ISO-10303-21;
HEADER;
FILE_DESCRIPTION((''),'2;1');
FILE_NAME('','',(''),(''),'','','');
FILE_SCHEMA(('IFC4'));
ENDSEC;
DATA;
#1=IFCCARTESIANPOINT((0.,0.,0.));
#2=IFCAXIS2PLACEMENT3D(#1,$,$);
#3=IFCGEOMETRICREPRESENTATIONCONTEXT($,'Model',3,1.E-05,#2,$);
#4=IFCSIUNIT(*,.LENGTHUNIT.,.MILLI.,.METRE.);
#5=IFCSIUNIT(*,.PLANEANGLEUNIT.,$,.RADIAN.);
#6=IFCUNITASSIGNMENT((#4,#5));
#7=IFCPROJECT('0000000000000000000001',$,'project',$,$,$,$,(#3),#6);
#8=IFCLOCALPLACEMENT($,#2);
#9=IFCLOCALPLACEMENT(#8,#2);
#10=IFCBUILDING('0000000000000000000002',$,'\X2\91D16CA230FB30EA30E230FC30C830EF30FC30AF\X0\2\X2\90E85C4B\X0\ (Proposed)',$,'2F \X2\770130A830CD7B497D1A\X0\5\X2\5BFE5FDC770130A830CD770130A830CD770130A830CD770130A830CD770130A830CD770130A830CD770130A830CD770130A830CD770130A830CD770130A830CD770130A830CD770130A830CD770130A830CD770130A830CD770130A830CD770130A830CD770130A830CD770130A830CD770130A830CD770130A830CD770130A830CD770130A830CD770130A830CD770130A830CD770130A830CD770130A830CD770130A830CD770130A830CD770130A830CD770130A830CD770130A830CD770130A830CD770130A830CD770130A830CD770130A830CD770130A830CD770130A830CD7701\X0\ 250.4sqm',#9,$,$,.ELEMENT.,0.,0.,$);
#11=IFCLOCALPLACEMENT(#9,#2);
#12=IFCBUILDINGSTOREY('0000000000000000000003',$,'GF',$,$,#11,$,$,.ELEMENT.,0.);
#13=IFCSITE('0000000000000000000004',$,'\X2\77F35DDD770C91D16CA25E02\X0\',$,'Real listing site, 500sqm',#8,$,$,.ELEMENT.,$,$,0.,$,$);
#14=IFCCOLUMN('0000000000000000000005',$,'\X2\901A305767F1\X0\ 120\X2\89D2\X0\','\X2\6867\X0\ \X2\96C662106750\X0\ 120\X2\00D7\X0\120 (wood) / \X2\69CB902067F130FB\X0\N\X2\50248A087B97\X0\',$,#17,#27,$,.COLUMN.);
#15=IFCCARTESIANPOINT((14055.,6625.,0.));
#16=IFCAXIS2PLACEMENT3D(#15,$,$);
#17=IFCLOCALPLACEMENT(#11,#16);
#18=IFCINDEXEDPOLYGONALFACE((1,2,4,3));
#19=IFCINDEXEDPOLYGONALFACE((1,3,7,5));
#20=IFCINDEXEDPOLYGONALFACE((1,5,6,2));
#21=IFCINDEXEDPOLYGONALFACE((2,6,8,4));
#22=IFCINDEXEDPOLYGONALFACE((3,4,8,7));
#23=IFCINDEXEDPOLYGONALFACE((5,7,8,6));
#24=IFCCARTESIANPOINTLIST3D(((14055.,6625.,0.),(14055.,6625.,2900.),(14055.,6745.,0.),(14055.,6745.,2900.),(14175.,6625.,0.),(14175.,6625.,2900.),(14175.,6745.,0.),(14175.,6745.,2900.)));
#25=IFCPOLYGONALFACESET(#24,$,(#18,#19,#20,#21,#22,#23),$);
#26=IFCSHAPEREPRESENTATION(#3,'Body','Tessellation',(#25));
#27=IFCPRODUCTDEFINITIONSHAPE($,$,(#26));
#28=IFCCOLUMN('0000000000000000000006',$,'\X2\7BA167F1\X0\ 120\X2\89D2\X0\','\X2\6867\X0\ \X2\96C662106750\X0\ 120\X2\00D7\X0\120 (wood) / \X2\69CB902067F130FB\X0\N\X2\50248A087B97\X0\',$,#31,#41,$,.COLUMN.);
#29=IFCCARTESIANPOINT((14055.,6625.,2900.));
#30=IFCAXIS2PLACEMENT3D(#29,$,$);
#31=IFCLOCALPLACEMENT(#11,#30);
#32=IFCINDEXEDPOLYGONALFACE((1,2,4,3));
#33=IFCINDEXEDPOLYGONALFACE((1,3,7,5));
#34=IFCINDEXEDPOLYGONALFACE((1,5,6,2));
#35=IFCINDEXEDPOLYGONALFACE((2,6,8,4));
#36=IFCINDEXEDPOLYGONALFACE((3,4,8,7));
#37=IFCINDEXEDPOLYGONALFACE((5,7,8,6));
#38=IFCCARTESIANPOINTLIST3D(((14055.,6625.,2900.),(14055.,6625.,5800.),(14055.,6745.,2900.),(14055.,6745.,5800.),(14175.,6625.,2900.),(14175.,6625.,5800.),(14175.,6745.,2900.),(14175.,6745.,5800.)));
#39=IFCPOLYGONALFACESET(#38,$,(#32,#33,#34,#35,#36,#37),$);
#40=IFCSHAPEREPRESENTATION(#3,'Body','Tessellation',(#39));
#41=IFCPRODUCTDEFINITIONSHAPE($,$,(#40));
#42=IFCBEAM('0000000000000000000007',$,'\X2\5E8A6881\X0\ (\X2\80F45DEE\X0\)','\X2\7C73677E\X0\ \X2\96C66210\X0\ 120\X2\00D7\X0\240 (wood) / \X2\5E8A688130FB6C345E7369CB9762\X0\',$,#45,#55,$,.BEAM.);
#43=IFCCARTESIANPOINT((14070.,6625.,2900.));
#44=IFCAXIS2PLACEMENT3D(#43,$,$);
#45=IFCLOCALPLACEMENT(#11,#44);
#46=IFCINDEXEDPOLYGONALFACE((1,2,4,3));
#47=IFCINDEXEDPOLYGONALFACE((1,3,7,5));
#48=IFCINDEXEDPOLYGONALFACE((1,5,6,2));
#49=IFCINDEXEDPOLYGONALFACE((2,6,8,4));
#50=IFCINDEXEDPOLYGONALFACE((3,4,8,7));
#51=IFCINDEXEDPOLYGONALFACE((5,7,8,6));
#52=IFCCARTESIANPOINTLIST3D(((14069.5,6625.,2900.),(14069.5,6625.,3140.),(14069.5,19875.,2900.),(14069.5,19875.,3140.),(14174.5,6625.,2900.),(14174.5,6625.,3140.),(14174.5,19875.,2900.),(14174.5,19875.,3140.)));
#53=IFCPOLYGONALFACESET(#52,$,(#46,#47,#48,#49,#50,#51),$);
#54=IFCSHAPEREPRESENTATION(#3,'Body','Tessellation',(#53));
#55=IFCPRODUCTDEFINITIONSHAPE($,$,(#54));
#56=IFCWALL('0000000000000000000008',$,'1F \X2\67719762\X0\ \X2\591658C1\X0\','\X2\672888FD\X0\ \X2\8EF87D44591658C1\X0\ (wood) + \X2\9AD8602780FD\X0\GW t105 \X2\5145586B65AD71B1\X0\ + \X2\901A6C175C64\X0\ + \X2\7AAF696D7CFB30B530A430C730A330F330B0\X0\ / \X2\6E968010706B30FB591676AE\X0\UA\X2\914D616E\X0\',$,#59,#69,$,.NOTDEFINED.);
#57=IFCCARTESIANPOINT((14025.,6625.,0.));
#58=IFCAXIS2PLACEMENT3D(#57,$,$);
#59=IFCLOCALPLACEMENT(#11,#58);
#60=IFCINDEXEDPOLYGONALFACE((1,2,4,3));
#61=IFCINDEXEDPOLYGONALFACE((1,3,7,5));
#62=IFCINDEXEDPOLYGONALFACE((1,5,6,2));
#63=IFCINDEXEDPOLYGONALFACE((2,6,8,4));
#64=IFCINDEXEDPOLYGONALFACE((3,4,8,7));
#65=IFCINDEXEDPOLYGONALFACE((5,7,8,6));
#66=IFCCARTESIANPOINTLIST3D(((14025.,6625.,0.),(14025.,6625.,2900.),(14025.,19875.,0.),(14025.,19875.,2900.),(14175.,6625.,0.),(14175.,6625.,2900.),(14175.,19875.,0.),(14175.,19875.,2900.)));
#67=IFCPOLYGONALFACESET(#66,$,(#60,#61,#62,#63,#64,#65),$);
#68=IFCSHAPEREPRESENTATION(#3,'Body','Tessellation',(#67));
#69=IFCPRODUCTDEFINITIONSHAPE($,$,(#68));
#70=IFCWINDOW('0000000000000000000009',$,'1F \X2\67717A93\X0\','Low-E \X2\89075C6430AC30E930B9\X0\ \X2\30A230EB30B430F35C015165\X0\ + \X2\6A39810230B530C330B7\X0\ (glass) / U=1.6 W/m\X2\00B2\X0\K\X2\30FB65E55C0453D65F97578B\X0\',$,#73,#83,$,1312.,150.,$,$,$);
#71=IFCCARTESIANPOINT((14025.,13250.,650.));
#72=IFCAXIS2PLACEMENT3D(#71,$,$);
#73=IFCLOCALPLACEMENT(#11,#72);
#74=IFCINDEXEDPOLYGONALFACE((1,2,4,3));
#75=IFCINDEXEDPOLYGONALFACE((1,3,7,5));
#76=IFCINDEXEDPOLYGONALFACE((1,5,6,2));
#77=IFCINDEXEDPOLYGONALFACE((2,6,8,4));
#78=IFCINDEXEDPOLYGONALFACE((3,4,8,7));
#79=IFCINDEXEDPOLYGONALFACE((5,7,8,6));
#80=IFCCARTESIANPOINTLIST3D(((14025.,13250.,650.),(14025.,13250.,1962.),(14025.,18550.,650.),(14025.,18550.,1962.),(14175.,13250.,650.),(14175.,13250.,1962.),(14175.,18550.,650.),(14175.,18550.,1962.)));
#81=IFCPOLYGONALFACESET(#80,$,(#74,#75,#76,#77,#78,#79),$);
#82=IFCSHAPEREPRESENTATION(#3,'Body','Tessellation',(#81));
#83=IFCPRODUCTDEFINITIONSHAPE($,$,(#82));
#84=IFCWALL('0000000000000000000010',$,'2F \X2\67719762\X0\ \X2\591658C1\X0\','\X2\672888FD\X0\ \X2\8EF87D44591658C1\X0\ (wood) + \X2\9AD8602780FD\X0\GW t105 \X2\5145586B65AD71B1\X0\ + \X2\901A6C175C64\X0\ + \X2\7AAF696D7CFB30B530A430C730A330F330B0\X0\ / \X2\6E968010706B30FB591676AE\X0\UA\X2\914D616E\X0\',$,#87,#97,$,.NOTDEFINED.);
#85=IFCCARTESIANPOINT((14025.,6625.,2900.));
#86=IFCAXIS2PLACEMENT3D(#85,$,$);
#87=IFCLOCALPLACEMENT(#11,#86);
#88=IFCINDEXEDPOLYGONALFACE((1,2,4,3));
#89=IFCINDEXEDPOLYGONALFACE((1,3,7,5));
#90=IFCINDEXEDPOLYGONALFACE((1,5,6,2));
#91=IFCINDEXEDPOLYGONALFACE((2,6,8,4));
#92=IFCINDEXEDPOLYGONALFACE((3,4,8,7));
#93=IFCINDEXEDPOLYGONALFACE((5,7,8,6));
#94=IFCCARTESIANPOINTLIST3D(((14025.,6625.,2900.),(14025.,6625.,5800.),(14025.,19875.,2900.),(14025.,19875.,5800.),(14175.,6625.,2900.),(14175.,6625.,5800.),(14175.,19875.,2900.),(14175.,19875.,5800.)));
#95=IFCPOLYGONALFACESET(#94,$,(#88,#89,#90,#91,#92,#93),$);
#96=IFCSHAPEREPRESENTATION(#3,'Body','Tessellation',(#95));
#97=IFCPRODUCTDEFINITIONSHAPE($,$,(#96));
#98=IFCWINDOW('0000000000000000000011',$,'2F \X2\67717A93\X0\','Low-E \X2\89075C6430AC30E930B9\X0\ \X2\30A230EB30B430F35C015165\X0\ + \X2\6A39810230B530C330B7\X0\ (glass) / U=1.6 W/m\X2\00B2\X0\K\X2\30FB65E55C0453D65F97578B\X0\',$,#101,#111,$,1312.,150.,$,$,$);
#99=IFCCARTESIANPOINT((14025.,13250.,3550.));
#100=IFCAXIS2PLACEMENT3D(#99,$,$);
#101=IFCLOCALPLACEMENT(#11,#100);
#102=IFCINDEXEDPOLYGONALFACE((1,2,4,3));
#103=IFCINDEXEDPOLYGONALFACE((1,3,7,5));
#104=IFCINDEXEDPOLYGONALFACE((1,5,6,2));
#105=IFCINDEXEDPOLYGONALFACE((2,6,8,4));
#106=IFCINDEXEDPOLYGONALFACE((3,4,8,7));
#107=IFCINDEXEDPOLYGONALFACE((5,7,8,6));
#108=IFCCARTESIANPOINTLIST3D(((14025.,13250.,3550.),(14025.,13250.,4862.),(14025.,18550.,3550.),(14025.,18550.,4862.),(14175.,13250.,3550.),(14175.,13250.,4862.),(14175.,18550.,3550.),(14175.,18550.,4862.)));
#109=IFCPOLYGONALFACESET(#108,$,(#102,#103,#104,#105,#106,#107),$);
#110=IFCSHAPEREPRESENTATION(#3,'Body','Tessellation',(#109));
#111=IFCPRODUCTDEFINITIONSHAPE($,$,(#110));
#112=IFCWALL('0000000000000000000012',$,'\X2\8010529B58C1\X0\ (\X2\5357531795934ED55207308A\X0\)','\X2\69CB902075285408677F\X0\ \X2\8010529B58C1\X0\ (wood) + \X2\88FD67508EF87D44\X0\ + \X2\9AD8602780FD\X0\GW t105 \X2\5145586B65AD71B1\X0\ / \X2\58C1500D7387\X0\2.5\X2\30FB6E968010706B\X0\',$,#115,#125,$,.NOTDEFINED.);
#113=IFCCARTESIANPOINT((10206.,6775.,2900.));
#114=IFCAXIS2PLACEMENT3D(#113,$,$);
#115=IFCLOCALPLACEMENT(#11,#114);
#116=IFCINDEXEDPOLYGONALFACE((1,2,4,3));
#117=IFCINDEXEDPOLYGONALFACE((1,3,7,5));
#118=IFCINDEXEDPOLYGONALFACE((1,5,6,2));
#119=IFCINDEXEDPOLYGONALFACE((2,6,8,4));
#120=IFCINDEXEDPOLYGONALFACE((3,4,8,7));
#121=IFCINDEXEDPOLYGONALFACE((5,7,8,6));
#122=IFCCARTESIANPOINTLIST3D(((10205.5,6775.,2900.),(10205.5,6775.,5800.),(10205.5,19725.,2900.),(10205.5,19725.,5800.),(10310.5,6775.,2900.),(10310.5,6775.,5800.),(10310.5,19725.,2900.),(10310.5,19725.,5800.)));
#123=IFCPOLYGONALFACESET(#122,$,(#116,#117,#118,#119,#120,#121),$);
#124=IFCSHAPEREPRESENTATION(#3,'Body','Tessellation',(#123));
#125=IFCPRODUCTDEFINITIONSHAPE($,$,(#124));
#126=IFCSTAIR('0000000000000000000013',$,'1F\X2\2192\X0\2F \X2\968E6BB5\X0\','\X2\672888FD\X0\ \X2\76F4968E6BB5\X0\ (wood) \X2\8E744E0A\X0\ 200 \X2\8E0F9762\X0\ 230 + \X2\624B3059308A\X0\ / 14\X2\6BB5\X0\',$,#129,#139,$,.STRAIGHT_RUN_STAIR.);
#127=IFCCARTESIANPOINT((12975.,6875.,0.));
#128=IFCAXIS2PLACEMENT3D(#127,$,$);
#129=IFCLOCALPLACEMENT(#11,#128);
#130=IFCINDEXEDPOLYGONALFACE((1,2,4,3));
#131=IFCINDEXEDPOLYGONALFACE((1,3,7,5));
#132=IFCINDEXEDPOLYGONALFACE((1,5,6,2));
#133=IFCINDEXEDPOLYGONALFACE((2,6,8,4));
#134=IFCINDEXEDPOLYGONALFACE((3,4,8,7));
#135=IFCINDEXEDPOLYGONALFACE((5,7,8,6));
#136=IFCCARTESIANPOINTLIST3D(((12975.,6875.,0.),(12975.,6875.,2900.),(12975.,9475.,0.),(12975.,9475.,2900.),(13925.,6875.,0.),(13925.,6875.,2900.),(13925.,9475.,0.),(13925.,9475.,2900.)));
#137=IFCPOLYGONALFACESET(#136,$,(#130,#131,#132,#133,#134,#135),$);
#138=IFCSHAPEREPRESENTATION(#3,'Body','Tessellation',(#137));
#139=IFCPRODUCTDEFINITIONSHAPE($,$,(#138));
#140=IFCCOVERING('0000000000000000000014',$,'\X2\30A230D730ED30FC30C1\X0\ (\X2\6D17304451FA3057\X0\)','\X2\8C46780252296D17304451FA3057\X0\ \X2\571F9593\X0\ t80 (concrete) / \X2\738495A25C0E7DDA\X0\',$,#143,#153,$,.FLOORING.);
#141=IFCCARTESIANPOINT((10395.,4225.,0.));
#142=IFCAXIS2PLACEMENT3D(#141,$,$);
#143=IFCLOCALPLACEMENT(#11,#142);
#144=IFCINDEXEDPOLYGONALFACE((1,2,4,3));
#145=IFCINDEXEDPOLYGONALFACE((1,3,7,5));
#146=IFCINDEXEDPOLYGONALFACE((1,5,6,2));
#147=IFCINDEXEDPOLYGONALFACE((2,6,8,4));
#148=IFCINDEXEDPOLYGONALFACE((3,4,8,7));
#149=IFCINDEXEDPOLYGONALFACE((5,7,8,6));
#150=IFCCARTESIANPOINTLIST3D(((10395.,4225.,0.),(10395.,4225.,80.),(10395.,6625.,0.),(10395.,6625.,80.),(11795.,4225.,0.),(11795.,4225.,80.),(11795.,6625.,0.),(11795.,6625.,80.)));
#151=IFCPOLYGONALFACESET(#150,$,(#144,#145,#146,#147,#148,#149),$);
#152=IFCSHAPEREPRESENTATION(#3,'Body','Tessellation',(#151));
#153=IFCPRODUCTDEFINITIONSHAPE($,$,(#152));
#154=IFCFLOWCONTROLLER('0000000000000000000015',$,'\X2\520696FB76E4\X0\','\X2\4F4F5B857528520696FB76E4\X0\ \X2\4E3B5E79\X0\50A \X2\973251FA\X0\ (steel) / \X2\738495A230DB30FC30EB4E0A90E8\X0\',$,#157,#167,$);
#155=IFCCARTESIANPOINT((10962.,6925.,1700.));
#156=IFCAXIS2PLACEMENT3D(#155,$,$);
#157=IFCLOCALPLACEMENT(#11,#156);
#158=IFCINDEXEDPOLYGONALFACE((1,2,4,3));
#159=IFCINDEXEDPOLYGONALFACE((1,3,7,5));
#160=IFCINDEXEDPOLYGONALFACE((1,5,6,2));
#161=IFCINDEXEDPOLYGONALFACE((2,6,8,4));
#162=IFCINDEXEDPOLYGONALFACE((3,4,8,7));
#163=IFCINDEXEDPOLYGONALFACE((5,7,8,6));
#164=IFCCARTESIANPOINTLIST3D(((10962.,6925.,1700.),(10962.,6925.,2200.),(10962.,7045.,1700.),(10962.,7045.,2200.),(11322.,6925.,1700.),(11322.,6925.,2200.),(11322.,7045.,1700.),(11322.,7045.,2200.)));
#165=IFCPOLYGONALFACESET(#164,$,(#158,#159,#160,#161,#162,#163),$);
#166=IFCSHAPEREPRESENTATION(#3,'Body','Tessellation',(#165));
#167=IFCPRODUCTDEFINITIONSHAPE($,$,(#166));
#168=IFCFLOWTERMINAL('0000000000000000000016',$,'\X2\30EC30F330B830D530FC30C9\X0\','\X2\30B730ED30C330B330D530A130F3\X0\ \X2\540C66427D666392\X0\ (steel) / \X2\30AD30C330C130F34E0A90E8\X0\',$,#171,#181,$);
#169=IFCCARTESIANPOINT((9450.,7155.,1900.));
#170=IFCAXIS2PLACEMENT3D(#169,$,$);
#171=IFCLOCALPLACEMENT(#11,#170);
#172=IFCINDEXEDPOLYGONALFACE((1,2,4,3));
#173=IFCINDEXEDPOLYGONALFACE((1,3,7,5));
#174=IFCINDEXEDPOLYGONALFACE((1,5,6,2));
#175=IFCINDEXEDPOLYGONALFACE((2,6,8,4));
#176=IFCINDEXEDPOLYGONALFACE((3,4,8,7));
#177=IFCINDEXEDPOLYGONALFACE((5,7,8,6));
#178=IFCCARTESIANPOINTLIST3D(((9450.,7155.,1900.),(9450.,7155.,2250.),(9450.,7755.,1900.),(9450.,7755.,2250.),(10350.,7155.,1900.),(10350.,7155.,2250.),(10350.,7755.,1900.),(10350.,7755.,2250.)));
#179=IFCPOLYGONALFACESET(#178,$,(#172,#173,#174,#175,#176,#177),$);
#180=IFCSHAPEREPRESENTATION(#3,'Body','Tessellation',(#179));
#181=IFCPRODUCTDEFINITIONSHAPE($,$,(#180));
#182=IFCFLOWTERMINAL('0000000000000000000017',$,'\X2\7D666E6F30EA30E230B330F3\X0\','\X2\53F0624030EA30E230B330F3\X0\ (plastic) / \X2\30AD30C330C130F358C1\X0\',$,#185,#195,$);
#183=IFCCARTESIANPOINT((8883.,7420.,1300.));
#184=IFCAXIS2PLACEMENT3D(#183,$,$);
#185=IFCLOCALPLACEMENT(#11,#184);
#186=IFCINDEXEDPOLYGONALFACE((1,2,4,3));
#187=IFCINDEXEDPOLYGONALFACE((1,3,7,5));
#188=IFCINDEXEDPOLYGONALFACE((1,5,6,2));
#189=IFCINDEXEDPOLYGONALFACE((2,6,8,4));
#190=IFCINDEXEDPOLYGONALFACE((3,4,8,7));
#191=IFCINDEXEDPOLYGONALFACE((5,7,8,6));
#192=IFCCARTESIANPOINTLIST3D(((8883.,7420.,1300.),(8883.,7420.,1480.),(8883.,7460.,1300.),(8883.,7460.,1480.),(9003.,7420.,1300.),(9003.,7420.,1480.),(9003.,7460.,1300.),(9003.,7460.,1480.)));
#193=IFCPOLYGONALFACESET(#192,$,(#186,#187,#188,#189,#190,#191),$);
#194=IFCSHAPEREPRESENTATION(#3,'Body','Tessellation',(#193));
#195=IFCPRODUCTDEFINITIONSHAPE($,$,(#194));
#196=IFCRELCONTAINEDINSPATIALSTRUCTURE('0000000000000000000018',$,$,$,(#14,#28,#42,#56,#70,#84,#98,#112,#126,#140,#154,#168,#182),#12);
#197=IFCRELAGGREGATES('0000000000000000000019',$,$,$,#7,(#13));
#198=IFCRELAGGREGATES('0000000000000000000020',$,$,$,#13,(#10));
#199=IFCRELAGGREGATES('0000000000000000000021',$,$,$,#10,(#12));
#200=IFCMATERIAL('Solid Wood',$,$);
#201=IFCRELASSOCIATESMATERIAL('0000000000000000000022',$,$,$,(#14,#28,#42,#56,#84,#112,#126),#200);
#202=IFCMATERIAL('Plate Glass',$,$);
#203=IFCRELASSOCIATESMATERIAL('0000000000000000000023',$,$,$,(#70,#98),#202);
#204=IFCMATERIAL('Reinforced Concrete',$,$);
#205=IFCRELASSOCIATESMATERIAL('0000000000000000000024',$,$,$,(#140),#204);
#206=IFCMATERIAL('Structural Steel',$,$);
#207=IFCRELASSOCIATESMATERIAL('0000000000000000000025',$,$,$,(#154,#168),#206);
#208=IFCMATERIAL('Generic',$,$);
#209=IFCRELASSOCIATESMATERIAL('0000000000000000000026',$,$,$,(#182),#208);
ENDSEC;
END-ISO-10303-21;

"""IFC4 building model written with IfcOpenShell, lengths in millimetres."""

from ifc_helpers import new_model, si_unit, frame, frame_2d, origin, place, context, project, spatial, rectangle, extrude, material, element, fill, save


model = new_model("IFC4")

# Units and contexts
model_context = context("Model", 3, precision=1e-05, world=origin())
ifc_project = project(units=[si_unit("LENGTHUNIT", "METRE", prefix="MILLI"), si_unit("PLANEANGLEUNIT", "RADIAN")], contexts=[model_context])

# Site, building, storey
site_placement = place(None, origin())
site = spatial("IfcSite", under=ifc_project, at=site_placement, Name="石川県金沢市", ObjectType="Real listing site, 500sqm", CompositionType="ELEMENT", RefElevation=0.0)
building_placement = place(site_placement, origin())
building = spatial("IfcBuilding", under=site, at=building_placement, Name="金沢・リモートワーク2部屋 (Proposed)", ObjectType="2F 省エネ等級5対応省エネ省エネ省エネ省エネ省エネ省エネ省エネ省エネ省エネ省エネ省エネ省エネ省エネ省エネ省エネ省エネ省エネ省エネ省エネ省エネ省エネ省エネ省エネ省エネ省エネ省エネ省エネ省エネ省エネ省エネ省エネ省エネ省エネ省エネ省エネ省エネ省エネ省 250.4sqm", CompositionType="ELEMENT", ElevationOfRefHeight=0.0, ElevationOfTerrain=0.0)
storey_placement = place(building_placement, origin())
storey = spatial("IfcBuildingStorey", under=building, at=storey_placement, Name="GF", CompositionType="ELEMENT", Elevation=0.0)

# Columns
ifc_material_1 = material(Name="Solid Wood")
column_1_placement = place(storey_placement, frame((14055.0, 6625.0, 0.0)))
element("IfcColumn", 1, at=column_1_placement, inside=storey, material=ifc_material_1, Name="通し柱 120角", Description="桧 集成材 120×120 (wood) / 構造柱・N値計算", PredefinedType="COLUMN", context=model_context, shape_type="SweptSolid", body=[
    extrude(rectangle(XDim=120.0, YDim=120.0, at=frame_2d((60.0, 60.0))), frame((14055.0, 6625.0, 0.0)), (0.0, 0.0, 1.0), 2900.0),
])
column_2_placement = place(storey_placement, frame((14055.0, 6625.0, 2900.0)))
element("IfcColumn", 2, at=column_2_placement, inside=storey, material=ifc_material_1, Name="管柱 120角", Description="桧 集成材 120×120 (wood) / 構造柱・N値計算", PredefinedType="COLUMN", context=model_context, shape_type="SweptSolid", body=[
    extrude(rectangle(XDim=120.0, YDim=120.0, at=frame_2d((60.0, 60.0))), frame((14055.0, 6625.0, 2900.0)), (0.0, 0.0, 1.0), 2900.0),
])

# Beam
beam_1_placement = place(storey_placement, frame((14070.0, 6625.0, 2900.0)))
element("IfcBeam", 3, at=beam_1_placement, inside=storey, material=ifc_material_1, Name="床梁 (胴差)", Description="米松 集成 120×240 (wood) / 床梁・水平構面", PredefinedType="BEAM", context=model_context, shape_type="SweptSolid", body=[
    extrude(rectangle(XDim=105.0, YDim=13250.0, at=frame_2d((52.0, 6625.0))), frame((14070.0, 6625.0, 2900.0)), (0.0, 0.0, 1.0), 240.0),
])

# Wall, opening, window
wall_1_placement = place(storey_placement, frame((14025.0, 6625.0, 0.0)))
wall_1 = element("IfcWall", 4, at=wall_1_placement, inside=storey, material=ifc_material_1, Name="1F 東面 外壁", Description="木製 軸組外壁 (wood) + 高性能GW t105 充填断熱 + 通気層 + 窯業系サイディング / 準耐火・外皮UA配慮", PredefinedType="NOTDEFINED", context=model_context, shape_type="SweptSolid", body=[
    extrude(rectangle(XDim=150.0, YDim=13250.0, at=frame_2d((75.0, 6625.0))), frame((14025.0, 6625.0, 0.0)), (0.0, 0.0, 1.0), 2900.0),
])
opening_1_placement = place(storey_placement, frame((14025.0, 13250.0, 650.0)))
opening_1 = element("IfcOpeningElement", 5, at=opening_1_placement, cuts=wall_1, PredefinedType="NOTDEFINED", context=model_context, shape_type="SweptSolid", body=[
    extrude(rectangle(XDim=150.0, YDim=5300.0, at=frame_2d((75.0, 2650.0))), frame((14025.0, 13250.0, 650.0)), (0.0, 0.0, 1.0), 1312.0),
])
ifc_material_2 = material(Name="Plate Glass")
window_1_placement = place(storey_placement, frame((14025.0, 13250.0, 650.0)))
window_1 = element("IfcWindow", 6, at=window_1_placement, inside=storey, material=ifc_material_2, Name="1F 東窓", Description="Low-E 複層ガラス アルゴン封入 + 樹脂サッシ (glass) / U=1.6 W/m²K・日射取得型", OverallHeight=1312.0, OverallWidth=150.0, context=model_context, shape_type="SweptSolid", body=[
    extrude(rectangle(XDim=150.0, YDim=5300.0, at=frame_2d((75.0, 2650.0))), frame((14025.0, 13250.0, 650.0)), (0.0, 0.0, 1.0), 1312.0),
])
fill(opening_1, window_1)

# Wall, opening, window
wall_2_placement = place(storey_placement, frame((14025.0, 6625.0, 2900.0)))
wall_2 = element("IfcWall", 7, at=wall_2_placement, inside=storey, material=ifc_material_1, Name="2F 東面 外壁", Description="木製 軸組外壁 (wood) + 高性能GW t105 充填断熱 + 通気層 + 窯業系サイディング / 準耐火・外皮UA配慮", PredefinedType="NOTDEFINED", context=model_context, shape_type="SweptSolid", body=[
    extrude(rectangle(XDim=150.0, YDim=13250.0, at=frame_2d((75.0, 6625.0))), frame((14025.0, 6625.0, 2900.0)), (0.0, 0.0, 1.0), 2900.0),
])
opening_2_placement = place(storey_placement, frame((14025.0, 13250.0, 3550.0)))
opening_2 = element("IfcOpeningElement", 8, at=opening_2_placement, cuts=wall_2, PredefinedType="NOTDEFINED", context=model_context, shape_type="SweptSolid", body=[
    extrude(rectangle(XDim=150.0, YDim=5300.0, at=frame_2d((75.0, 2650.0))), frame((14025.0, 13250.0, 3550.0)), (0.0, 0.0, 1.0), 1312.0),
])
window_2_placement = place(storey_placement, frame((14025.0, 13250.0, 3550.0)))
window_2 = element("IfcWindow", 9, at=window_2_placement, inside=storey, material=ifc_material_2, Name="2F 東窓", Description="Low-E 複層ガラス アルゴン封入 + 樹脂サッシ (glass) / U=1.6 W/m²K・日射取得型", OverallHeight=1312.0, OverallWidth=150.0, context=model_context, shape_type="SweptSolid", body=[
    extrude(rectangle(XDim=150.0, YDim=5300.0, at=frame_2d((75.0, 2650.0))), frame((14025.0, 13250.0, 3550.0)), (0.0, 0.0, 1.0), 1312.0),
])
fill(opening_2, window_2)

# Wall
wall_3_placement = place(storey_placement, frame((10206.0, 6775.0, 2900.0)))
element("IfcWall", 10, at=wall_3_placement, inside=storey, material=ifc_material_1, Name="耐力壁 (南北間仕切り)", Description="構造用合板 耐力壁 (wood) + 製材軸組 + 高性能GW t105 充填断熱 / 壁倍率2.5・準耐火", PredefinedType="NOTDEFINED", context=model_context, shape_type="SweptSolid", body=[
    extrude(rectangle(XDim=105.0, YDim=12950.0, at=frame_2d((52.0, 6475.0))), frame((10206.0, 6775.0, 2900.0)), (0.0, 0.0, 1.0), 2900.0),
])

# Stair
stair_placement = place(storey_placement, frame((12975.0, 6875.0, 0.0)))
element("IfcStair", 11, at=stair_placement, inside=storey, material=ifc_material_1, Name="1F→2F 階段", Description="木製 直階段 (wood) 蹴上 200 踏面 230 + 手すり / 14段", PredefinedType="STRAIGHT_RUN_STAIR", context=model_context, shape_type="SweptSolid", body=[
    extrude(rectangle(XDim=950.0, YDim=2600.0, at=frame_2d((475.0, 1300.0))), frame((12975.0, 6875.0, 0.0)), (0.0, 0.0, 1.0), 2900.0),
])

# Covering
ifc_material_3 = material(Name="Reinforced Concrete")
covering_placement = place(storey_placement, frame((10395.0, 4225.0, 0.0)))
element("IfcCovering", 12, at=covering_placement, inside=storey, material=ifc_material_3, Name="アプローチ (洗い出し)", Description="豆砂利洗い出し 土間 t80 (concrete) / 玄関導線", PredefinedType="FLOORING", context=model_context, shape_type="SweptSolid", body=[
    extrude(rectangle(XDim=1400.0, YDim=2400.0, at=frame_2d((700.0, 1200.0))), frame((10395.0, 4225.0, 0.0)), (0.0, 0.0, 1.0), 80.0),
])

# Flow controller
ifc_material_4 = material(Name="Structural Steel")
flow_controller_placement = place(storey_placement, frame((10962.0, 6925.0, 1700.0)))
element("IfcFlowController", 13, at=flow_controller_placement, inside=storey, material=ifc_material_4, Name="分電盤", Description="住宅用分電盤 主幹50A 露出 (steel) / 玄関ホール上部", context=model_context, shape_type="SweptSolid", body=[
    extrude(rectangle(XDim=360.0, YDim=120.0, at=frame_2d((180.0, 60.0))), frame((10962.0, 6925.0, 1700.0)), (0.0, 0.0, 1.0), 500.0),
])

# Flow terminals
flow_terminal_1_placement = place(storey_placement, frame((9450.0, 7155.0, 1900.0)))
element("IfcFlowTerminal", 14, at=flow_terminal_1_placement, inside=storey, material=ifc_material_4, Name="レンジフード", Description="シロッコファン 同時給排 (steel) / キッチン上部", context=model_context, shape_type="SweptSolid", body=[
    extrude(rectangle(XDim=900.0, YDim=600.0, at=frame_2d((450.0, 300.0))), frame((9450.0, 7155.0, 1900.0)), (0.0, 0.0, 1.0), 350.0),
])
ifc_material_5 = material(Name="Generic")
flow_terminal_2_placement = place(storey_placement, frame((8883.0, 7420.0, 1300.0)))
element("IfcFlowTerminal", 15, at=flow_terminal_2_placement, inside=storey, material=ifc_material_5, Name="給湯リモコン", Description="台所リモコン (plastic) / キッチン壁", context=model_context, shape_type="SweptSolid", body=[
    extrude(rectangle(XDim=120.0, YDim=40.0, at=frame_2d((60.0, 20.0))), frame((8883.0, 7420.0, 1300.0)), (0.0, 0.0, 1.0), 180.0),
])

save(model, "model.ifc")
